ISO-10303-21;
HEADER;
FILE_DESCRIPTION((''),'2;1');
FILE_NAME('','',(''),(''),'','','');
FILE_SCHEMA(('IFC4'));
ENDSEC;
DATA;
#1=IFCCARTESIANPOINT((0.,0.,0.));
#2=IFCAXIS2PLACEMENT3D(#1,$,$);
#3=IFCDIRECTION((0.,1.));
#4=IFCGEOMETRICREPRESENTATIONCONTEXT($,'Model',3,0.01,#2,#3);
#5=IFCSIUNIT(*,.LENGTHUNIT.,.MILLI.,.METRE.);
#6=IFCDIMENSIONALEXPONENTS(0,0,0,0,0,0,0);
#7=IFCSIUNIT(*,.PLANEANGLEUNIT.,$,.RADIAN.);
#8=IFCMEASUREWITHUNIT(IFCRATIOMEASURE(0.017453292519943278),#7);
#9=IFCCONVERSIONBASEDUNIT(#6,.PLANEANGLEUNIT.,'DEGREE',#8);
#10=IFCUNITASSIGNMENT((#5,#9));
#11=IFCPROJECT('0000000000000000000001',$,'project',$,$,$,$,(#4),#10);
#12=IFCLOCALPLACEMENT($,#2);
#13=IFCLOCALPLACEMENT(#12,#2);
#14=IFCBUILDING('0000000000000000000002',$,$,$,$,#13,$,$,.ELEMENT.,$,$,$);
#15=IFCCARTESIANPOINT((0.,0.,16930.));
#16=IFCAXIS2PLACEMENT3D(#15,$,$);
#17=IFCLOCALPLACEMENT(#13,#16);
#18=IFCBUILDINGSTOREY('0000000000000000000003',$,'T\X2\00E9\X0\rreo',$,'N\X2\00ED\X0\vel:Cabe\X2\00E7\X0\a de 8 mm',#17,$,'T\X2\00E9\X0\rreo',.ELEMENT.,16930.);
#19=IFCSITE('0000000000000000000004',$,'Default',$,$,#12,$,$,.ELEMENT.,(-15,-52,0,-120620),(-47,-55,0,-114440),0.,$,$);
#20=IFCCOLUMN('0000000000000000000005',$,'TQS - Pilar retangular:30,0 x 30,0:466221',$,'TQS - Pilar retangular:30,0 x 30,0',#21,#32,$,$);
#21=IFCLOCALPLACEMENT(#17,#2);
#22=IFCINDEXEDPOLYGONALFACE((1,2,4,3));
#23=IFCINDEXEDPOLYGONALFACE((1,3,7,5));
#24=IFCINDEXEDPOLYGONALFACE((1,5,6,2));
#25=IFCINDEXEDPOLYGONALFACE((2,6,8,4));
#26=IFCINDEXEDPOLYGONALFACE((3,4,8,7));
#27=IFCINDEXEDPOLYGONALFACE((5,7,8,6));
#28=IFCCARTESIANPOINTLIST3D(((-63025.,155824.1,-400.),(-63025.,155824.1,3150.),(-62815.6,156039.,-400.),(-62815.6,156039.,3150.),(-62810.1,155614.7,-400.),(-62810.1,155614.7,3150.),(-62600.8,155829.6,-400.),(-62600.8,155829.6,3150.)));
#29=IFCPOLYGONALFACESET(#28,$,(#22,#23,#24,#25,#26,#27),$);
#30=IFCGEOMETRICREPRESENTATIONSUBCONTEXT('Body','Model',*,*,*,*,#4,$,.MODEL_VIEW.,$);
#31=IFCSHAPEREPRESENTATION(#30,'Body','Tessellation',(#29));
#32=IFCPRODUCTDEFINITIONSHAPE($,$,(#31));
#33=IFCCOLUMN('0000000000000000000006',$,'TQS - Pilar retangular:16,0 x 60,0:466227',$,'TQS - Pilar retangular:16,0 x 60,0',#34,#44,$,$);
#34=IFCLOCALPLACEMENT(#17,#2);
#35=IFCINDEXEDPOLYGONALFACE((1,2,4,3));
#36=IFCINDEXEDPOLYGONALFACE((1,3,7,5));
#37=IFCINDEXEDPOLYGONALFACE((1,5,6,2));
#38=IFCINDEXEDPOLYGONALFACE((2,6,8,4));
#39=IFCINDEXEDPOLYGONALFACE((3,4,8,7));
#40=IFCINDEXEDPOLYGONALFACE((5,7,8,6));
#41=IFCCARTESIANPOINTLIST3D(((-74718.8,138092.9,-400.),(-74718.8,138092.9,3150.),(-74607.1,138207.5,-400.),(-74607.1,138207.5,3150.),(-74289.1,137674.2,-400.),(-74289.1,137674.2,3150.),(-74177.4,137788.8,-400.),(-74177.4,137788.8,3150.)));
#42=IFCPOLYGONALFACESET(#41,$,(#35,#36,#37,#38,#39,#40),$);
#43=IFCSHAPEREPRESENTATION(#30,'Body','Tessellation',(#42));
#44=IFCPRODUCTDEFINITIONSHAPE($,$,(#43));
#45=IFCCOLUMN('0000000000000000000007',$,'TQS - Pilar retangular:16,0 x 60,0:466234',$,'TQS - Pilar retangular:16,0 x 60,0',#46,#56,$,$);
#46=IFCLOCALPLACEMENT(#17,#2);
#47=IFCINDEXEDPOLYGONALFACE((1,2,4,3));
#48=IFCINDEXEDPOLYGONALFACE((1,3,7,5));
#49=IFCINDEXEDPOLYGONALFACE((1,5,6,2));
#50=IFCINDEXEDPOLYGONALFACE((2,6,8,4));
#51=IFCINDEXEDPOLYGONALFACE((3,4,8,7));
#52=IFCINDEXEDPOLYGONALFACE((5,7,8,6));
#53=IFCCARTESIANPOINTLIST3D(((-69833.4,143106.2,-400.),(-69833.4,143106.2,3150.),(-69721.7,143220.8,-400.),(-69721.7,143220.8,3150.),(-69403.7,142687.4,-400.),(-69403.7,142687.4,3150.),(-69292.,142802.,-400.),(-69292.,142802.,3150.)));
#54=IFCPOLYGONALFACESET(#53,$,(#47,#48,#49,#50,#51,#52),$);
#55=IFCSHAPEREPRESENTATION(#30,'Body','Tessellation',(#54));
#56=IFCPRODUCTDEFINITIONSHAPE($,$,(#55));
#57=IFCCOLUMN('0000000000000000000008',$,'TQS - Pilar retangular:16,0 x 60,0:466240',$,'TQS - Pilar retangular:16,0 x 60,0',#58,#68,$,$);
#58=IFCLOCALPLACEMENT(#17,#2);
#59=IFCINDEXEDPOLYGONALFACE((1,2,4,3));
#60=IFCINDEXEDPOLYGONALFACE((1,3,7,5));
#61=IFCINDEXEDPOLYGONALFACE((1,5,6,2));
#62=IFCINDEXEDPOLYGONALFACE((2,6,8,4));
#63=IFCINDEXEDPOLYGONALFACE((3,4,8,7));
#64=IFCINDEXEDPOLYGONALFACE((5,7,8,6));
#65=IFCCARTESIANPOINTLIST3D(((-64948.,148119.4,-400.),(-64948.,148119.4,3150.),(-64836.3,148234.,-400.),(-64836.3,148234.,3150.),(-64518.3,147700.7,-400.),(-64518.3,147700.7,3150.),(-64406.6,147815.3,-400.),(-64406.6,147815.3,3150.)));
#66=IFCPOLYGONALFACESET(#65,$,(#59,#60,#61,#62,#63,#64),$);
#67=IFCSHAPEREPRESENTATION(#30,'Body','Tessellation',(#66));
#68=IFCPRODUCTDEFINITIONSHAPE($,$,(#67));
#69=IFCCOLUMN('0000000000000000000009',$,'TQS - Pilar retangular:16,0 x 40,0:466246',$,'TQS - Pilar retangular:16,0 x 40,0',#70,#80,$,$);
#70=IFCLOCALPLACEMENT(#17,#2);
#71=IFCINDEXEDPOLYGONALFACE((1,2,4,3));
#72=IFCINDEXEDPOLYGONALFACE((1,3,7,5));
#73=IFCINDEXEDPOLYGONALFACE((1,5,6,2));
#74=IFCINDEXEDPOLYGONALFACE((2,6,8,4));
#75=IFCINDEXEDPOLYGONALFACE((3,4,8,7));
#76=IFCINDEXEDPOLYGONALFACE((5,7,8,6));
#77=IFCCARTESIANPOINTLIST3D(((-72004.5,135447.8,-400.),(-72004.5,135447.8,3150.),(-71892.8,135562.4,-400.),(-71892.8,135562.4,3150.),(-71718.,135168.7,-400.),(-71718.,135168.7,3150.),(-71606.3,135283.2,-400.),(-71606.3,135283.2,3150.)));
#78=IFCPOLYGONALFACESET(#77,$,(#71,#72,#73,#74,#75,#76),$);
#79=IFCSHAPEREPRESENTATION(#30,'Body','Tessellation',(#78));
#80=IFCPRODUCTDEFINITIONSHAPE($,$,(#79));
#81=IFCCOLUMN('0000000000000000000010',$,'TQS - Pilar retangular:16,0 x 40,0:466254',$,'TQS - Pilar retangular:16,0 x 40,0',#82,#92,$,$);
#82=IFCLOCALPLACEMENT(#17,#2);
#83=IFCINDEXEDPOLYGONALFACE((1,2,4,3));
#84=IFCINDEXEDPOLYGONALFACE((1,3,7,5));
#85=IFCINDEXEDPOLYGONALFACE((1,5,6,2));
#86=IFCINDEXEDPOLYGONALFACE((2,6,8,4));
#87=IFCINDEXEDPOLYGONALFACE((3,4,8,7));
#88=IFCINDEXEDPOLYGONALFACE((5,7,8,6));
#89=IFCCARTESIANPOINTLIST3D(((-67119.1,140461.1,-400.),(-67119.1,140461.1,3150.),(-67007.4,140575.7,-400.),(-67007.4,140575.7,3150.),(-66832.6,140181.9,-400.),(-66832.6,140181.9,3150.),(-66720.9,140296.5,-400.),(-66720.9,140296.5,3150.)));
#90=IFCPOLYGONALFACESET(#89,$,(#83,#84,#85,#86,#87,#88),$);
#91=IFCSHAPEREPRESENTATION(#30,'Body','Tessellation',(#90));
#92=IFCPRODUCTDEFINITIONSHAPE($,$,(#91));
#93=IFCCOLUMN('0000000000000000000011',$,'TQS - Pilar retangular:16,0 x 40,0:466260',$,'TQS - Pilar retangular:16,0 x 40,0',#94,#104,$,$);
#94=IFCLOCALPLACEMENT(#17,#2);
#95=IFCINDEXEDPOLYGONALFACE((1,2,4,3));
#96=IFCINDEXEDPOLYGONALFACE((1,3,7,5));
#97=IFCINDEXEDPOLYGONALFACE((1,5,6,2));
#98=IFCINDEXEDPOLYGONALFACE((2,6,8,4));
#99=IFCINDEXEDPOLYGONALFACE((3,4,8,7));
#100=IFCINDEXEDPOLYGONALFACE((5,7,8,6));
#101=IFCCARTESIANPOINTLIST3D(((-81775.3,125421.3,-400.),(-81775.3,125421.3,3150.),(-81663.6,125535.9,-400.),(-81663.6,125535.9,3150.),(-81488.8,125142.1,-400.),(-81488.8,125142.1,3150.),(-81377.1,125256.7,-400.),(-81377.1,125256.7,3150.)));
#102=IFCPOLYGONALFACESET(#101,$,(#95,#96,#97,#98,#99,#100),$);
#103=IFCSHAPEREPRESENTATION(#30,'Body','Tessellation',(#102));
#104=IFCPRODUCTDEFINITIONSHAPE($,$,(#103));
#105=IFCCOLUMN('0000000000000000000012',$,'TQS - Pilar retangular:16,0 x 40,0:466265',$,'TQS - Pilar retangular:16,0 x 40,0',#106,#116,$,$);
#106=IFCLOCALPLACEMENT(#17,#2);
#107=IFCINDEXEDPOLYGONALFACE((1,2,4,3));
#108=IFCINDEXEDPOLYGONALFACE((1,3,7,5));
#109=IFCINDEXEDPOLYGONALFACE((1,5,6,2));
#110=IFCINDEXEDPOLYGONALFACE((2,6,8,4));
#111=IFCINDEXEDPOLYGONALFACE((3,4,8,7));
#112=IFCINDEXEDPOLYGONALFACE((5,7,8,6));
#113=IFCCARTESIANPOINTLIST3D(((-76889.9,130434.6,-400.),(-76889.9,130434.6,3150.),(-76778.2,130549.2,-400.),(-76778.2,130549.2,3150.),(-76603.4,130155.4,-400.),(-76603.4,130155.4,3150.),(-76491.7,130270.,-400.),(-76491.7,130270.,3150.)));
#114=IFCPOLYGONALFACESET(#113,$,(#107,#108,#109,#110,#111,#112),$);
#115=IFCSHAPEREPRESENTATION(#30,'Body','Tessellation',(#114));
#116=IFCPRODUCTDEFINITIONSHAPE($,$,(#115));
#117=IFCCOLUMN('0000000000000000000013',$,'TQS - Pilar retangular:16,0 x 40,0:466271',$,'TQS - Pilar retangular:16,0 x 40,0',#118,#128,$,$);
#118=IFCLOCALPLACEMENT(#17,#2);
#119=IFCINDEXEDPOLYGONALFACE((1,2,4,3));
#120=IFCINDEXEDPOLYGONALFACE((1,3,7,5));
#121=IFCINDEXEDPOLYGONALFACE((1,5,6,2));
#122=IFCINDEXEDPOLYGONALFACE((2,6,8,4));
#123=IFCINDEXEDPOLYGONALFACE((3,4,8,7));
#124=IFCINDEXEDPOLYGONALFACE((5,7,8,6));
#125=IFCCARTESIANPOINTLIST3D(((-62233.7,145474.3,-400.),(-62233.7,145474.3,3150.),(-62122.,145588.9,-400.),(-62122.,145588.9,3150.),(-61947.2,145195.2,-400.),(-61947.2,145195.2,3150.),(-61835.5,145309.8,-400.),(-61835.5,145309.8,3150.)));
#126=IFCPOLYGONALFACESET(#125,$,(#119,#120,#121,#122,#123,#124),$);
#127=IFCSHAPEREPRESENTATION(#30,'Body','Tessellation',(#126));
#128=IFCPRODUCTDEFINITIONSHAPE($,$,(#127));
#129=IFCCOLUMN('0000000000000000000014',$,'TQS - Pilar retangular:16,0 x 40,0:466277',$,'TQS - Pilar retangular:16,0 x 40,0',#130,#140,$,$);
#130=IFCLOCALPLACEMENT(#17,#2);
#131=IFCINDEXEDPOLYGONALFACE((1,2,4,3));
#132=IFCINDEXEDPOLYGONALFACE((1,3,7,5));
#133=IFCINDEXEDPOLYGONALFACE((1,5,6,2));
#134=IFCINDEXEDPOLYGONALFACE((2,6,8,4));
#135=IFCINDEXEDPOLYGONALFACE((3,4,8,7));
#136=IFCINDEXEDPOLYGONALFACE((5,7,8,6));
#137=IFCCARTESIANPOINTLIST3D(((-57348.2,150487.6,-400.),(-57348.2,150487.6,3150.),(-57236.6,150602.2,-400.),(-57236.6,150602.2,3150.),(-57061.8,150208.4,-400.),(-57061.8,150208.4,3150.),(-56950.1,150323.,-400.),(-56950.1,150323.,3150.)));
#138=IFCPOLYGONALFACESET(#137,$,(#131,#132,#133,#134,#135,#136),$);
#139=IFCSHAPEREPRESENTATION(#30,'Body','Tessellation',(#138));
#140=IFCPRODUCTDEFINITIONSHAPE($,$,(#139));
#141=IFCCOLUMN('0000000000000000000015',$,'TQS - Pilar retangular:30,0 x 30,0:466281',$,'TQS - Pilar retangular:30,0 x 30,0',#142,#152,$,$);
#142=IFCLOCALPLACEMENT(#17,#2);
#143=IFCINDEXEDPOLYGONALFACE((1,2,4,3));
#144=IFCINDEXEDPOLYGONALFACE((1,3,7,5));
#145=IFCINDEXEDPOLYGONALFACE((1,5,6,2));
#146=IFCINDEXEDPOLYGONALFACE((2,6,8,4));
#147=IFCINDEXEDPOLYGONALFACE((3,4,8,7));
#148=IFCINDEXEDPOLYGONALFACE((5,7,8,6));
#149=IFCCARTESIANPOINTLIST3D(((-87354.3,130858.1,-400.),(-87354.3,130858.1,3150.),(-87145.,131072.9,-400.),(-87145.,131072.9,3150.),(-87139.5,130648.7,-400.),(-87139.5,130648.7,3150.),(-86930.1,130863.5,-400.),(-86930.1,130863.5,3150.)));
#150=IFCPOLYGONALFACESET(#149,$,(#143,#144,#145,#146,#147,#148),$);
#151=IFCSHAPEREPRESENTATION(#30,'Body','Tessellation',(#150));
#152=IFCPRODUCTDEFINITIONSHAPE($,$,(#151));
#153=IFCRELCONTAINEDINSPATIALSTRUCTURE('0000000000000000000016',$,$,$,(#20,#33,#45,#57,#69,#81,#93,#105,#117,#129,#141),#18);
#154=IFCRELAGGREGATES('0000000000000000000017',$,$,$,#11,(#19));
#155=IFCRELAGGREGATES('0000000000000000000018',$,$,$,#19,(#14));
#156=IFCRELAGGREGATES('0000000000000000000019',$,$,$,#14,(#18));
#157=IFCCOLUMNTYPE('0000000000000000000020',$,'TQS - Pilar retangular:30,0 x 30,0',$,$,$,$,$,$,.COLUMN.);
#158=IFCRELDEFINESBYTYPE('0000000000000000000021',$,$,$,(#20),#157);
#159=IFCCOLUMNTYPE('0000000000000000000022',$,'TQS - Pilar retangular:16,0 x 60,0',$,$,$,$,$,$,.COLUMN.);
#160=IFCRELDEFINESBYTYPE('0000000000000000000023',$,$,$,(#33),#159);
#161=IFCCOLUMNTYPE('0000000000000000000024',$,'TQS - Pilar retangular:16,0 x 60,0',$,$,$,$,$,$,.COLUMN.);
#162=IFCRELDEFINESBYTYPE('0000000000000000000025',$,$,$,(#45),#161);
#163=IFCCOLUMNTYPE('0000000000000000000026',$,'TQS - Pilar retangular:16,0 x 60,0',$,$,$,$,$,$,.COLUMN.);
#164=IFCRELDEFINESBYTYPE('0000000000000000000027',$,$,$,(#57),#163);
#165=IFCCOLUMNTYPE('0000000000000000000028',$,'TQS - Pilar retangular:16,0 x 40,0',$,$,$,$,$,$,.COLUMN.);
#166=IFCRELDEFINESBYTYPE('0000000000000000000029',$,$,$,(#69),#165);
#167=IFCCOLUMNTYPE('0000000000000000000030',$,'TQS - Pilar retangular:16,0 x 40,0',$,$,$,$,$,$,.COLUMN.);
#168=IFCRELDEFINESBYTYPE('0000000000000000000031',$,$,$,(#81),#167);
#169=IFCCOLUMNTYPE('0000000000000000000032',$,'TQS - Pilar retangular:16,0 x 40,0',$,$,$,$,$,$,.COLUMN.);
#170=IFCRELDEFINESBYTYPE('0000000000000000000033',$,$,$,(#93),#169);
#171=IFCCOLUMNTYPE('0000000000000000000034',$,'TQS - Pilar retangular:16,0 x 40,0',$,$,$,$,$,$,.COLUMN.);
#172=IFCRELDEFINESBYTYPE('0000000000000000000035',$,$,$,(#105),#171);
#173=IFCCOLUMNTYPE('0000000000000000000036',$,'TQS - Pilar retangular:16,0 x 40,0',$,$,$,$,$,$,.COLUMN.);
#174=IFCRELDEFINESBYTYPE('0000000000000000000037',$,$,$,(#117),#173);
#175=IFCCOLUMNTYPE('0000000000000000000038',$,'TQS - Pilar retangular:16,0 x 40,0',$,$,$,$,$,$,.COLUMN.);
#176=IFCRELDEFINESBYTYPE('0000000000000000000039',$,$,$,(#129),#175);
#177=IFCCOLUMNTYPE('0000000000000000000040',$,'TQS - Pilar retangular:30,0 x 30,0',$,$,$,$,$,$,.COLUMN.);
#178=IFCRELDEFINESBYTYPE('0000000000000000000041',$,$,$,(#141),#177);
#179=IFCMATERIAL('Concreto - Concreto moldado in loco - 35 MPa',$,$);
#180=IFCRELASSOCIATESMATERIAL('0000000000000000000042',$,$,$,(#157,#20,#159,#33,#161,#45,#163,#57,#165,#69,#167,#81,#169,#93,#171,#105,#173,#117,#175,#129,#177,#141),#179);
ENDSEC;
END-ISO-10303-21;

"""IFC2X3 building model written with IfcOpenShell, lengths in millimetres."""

from ifc_helpers import new_model, entity, si_unit, converted_unit, direction, frame, frame_2d, origin, origin_2d_with_axis, place, context, subcontext, project, spatial, rectangle, extrude, source, transform, mapped, material, type_object, type_shapes, element, save


model = new_model("IFC2X3")

# Units and contexts
model_context = context("Model", 3, precision=0.01, world=origin(), true_north=direction((0.0, 1.0)))
body_context = subcontext(model_context, "Body", "Model", "MODEL_VIEW")
ifc_project = project(units=[si_unit("LENGTHUNIT", "METRE", prefix="MILLI"), converted_unit("PLANEANGLEUNIT", "DEGREE", entity("IfcRatioMeasure", 0.017453292519943278), si_unit("PLANEANGLEUNIT", "RADIAN"), dimensions=[0, 0, 0, 0, 0, 0, 0])], contexts=[model_context])

# Site, building, storey
site_placement = place(None, origin())
site = spatial("IfcSite", under=ifc_project, at=site_placement, Name="Default", CompositionType="ELEMENT", RefLatitude=(-15, -52, 0, -120620), RefLongitude=(-47, -55, 0, -114440), RefElevation=0.0)
building_placement = place(site_placement, origin())
building = spatial("IfcBuilding", under=site, at=building_placement, CompositionType="ELEMENT")
storey_placement = place(building_placement, frame((0.0, 0.0, 16930.0)))
storey = spatial("IfcBuildingStorey", under=building, at=storey_placement, Name="Térreo", ObjectType="Nível:Cabeça de 8 mm", LongName="Térreo", CompositionType="ELEMENT", Elevation=16930.0)

# Columns
ifc_material = material(Name="Concreto - Concreto moldado in loco - 35 MPa")
column_type_1 = type_object("IfcColumnType", Name="TQS - Pilar retangular:30,0 x 30,0", PredefinedType="COLUMN", material=ifc_material)
shared_shape_1 = source(origin(), body_context, "Body", "SweptSolid", [
    extrude(rectangle(XDim=300.0, YDim=300.0, at=origin_2d_with_axis()), frame((-62812.9, 155826.8, 16530.0), z_axis=(0.0, 0.0, 1.0), x_axis=(-0.71618, 0.697915, 0.0)), (0.0, 0.0, 1.0), 3550.0),
])
type_shapes(column_type_1, [shared_shape_1])
column_1_placement = place(storey_placement, frame((0.0, 0.0, -16930.0)))
element("IfcColumn", 1, at=column_1_placement, inside=storey, type_object=column_type_1, material=ifc_material, Name="TQS - Pilar retangular:30,0 x 30,0:466221", ObjectType="TQS - Pilar retangular:30,0 x 30,0", context=body_context, shape_type="MappedRepresentation", body=[
    mapped(shared_shape_1, transform((0.0, 0.0, 0.0), scale=1.0)),
])
column_type_2 = type_object("IfcColumnType", Name="TQS - Pilar retangular:16,0 x 60,0", PredefinedType="COLUMN", material=ifc_material)
shared_shape_2 = source(origin(), body_context, "Body", "SweptSolid", [
    extrude(rectangle(XDim=600.0, YDim=160.0, at=frame_2d((0.0, 0.0), x_axis=(1.0, 0.0))), frame((-74448.1, 137940.8, 16530.0), z_axis=(0.0, 0.0, 1.0), x_axis=(-0.71618, 0.697915, 0.0)), (0.0, 0.0, 1.0), 3550.0),
])
type_shapes(column_type_2, [shared_shape_2])
column_2_placement = place(storey_placement, frame((0.0, 0.0, -16930.0)))
element("IfcColumn", 2, at=column_2_placement, inside=storey, type_object=column_type_2, material=ifc_material, Name="TQS - Pilar retangular:16,0 x 60,0:466227", ObjectType="TQS - Pilar retangular:16,0 x 60,0", context=body_context, shape_type="MappedRepresentation", body=[
    mapped(shared_shape_2, transform((0.0, 0.0, 0.0), scale=1.0)),
])
column_type_3 = type_object("IfcColumnType", Name="TQS - Pilar retangular:16,0 x 60,0", PredefinedType="COLUMN", material=ifc_material)
shared_shape_3 = source(origin(), body_context, "Body", "SweptSolid", [
    extrude(rectangle(XDim=600.0, YDim=160.0, at=frame_2d((0.0, 0.0), x_axis=(1.0, 0.0))), frame((-69562.7, 142954.1, 16530.0), z_axis=(0.0, 0.0, 1.0), x_axis=(-0.71618, 0.697915, 0.0)), (0.0, 0.0, 1.0), 3550.0),
])
type_shapes(column_type_3, [shared_shape_3])
column_3_placement = place(storey_placement, frame((0.0, 0.0, -16930.0)))
element("IfcColumn", 3, at=column_3_placement, inside=storey, type_object=column_type_3, material=ifc_material, Name="TQS - Pilar retangular:16,0 x 60,0:466234", ObjectType="TQS - Pilar retangular:16,0 x 60,0", context=body_context, shape_type="MappedRepresentation", body=[
    mapped(shared_shape_3, transform((0.0, 0.0, 0.0), scale=1.0)),
])
column_type_4 = type_object("IfcColumnType", Name="TQS - Pilar retangular:16,0 x 60,0", PredefinedType="COLUMN", material=ifc_material)
shared_shape_4 = source(origin(), body_context, "Body", "SweptSolid", [
    extrude(rectangle(XDim=600.0, YDim=160.0, at=frame_2d((0.0, 0.0), x_axis=(1.0, 0.0))), frame((-64677.3, 147967.4, 16530.0), z_axis=(0.0, 0.0, 1.0), x_axis=(-0.71618, 0.697915, 0.0)), (0.0, 0.0, 1.0), 3550.0),
])
type_shapes(column_type_4, [shared_shape_4])
column_4_placement = place(storey_placement, frame((0.0, 0.0, -16930.0)))
element("IfcColumn", 4, at=column_4_placement, inside=storey, type_object=column_type_4, material=ifc_material, Name="TQS - Pilar retangular:16,0 x 60,0:466240", ObjectType="TQS - Pilar retangular:16,0 x 60,0", context=body_context, shape_type="MappedRepresentation", body=[
    mapped(shared_shape_4, transform((0.0, 0.0, 0.0), scale=1.0)),
])
column_type_5 = type_object("IfcColumnType", Name="TQS - Pilar retangular:16,0 x 40,0", PredefinedType="COLUMN", material=ifc_material)
shared_shape_5 = source(origin(), body_context, "Body", "SweptSolid", [
    extrude(rectangle(XDim=400.0, YDim=160.0, at=frame_2d((0.0, 0.0), x_axis=(1.0, 0.0))), frame((-71805.4, 135365.5, 16530.0), z_axis=(0.0, 0.0, 1.0), x_axis=(-0.71618, 0.697915, 0.0)), (0.0, 0.0, 1.0), 3550.0),
])
type_shapes(column_type_5, [shared_shape_5])
column_5_placement = place(storey_placement, frame((0.0, 0.0, -16930.0)))
element("IfcColumn", 5, at=column_5_placement, inside=storey, type_object=column_type_5, material=ifc_material, Name="TQS - Pilar retangular:16,0 x 40,0:466246", ObjectType="TQS - Pilar retangular:16,0 x 40,0", context=body_context, shape_type="MappedRepresentation", body=[
    mapped(shared_shape_5, transform((0.0, 0.0, 0.0), scale=1.0)),
])
column_type_6 = type_object("IfcColumnType", Name="TQS - Pilar retangular:16,0 x 40,0", PredefinedType="COLUMN", material=ifc_material)
shared_shape_6 = source(origin(), body_context, "Body", "SweptSolid", [
    extrude(rectangle(XDim=400.0, YDim=160.0, at=frame_2d((0.0, 0.0), x_axis=(1.0, 0.0))), frame((-66920.0, 140378.8, 16530.0), z_axis=(0.0, 0.0, 1.0), x_axis=(-0.71618, 0.697915, 0.0)), (0.0, 0.0, 1.0), 3550.0),
])
type_shapes(column_type_6, [shared_shape_6])
column_6_placement = place(storey_placement, frame((0.0, 0.0, -16930.0)))
element("IfcColumn", 6, at=column_6_placement, inside=storey, type_object=column_type_6, material=ifc_material, Name="TQS - Pilar retangular:16,0 x 40,0:466254", ObjectType="TQS - Pilar retangular:16,0 x 40,0", context=body_context, shape_type="MappedRepresentation", body=[
    mapped(shared_shape_6, transform((0.0, 0.0, 0.0), scale=1.0)),
])
column_type_7 = type_object("IfcColumnType", Name="TQS - Pilar retangular:16,0 x 40,0", PredefinedType="COLUMN", material=ifc_material)
shared_shape_7 = source(origin(), body_context, "Body", "SweptSolid", [
    extrude(rectangle(XDim=400.0, YDim=160.0, at=frame_2d((0.0, 0.0), x_axis=(1.0, 0.0))), frame((-81576.2, 125339.0, 16530.0), z_axis=(0.0, 0.0, 1.0), x_axis=(-0.71618, 0.697915, 0.0)), (0.0, 0.0, 1.0), 3550.0),
])
type_shapes(column_type_7, [shared_shape_7])
column_7_placement = place(storey_placement, frame((0.0, 0.0, -16930.0)))
element("IfcColumn", 7, at=column_7_placement, inside=storey, type_object=column_type_7, material=ifc_material, Name="TQS - Pilar retangular:16,0 x 40,0:466260", ObjectType="TQS - Pilar retangular:16,0 x 40,0", context=body_context, shape_type="MappedRepresentation", body=[
    mapped(shared_shape_7, transform((0.0, 0.0, 0.0), scale=1.0)),
])
column_type_8 = type_object("IfcColumnType", Name="TQS - Pilar retangular:16,0 x 40,0", PredefinedType="COLUMN", material=ifc_material)
shared_shape_8 = source(origin(), body_context, "Body", "SweptSolid", [
    extrude(rectangle(XDim=400.0, YDim=160.0, at=frame_2d((0.0, 0.0), x_axis=(1.0, 0.0))), frame((-76690.8, 130352.3, 16530.0), z_axis=(0.0, 0.0, 1.0), x_axis=(-0.71618, 0.697915, 0.0)), (0.0, 0.0, 1.0), 3550.0),
])
type_shapes(column_type_8, [shared_shape_8])
column_8_placement = place(storey_placement, frame((0.0, 0.0, -16930.0)))
element("IfcColumn", 8, at=column_8_placement, inside=storey, type_object=column_type_8, material=ifc_material, Name="TQS - Pilar retangular:16,0 x 40,0:466265", ObjectType="TQS - Pilar retangular:16,0 x 40,0", context=body_context, shape_type="MappedRepresentation", body=[
    mapped(shared_shape_8, transform((0.0, 0.0, 0.0), scale=1.0)),
])
column_type_9 = type_object("IfcColumnType", Name="TQS - Pilar retangular:16,0 x 40,0", PredefinedType="COLUMN", material=ifc_material)
shared_shape_9 = source(origin(), body_context, "Body", "SweptSolid", [
    extrude(rectangle(XDim=400.0, YDim=160.0, at=frame_2d((0.0, 0.0), x_axis=(1.0, 0.0))), frame((-62034.6, 145392.1, 16530.0), z_axis=(0.0, 0.0, 1.0), x_axis=(-0.71618, 0.697915, 0.0)), (0.0, 0.0, 1.0), 3550.0),
])
type_shapes(column_type_9, [shared_shape_9])
column_9_placement = place(storey_placement, frame((0.0, 0.0, -16930.0)))
element("IfcColumn", 9, at=column_9_placement, inside=storey, type_object=column_type_9, material=ifc_material, Name="TQS - Pilar retangular:16,0 x 40,0:466271", ObjectType="TQS - Pilar retangular:16,0 x 40,0", context=body_context, shape_type="MappedRepresentation", body=[
    mapped(shared_shape_9, transform((0.0, 0.0, 0.0), scale=1.0)),
])
column_type_10 = type_object("IfcColumnType", Name="TQS - Pilar retangular:16,0 x 40,0", PredefinedType="COLUMN", material=ifc_material)
shared_shape_10 = source(origin(), body_context, "Body", "SweptSolid", [
    extrude(rectangle(XDim=400.0, YDim=160.0, at=frame_2d((0.0, 0.0), x_axis=(1.0, 0.0))), frame((-57149.2, 150405.3, 16530.0), z_axis=(0.0, 0.0, 1.0), x_axis=(-0.71618, 0.697915, 0.0)), (0.0, 0.0, 1.0), 3550.0),
])
type_shapes(column_type_10, [shared_shape_10])
column_10_placement = place(storey_placement, frame((0.0, 0.0, -16930.0)))
element("IfcColumn", 10, at=column_10_placement, inside=storey, type_object=column_type_10, material=ifc_material, Name="TQS - Pilar retangular:16,0 x 40,0:466277", ObjectType="TQS - Pilar retangular:16,0 x 40,0", context=body_context, shape_type="MappedRepresentation", body=[
    mapped(shared_shape_10, transform((0.0, 0.0, 0.0), scale=1.0)),
])
column_type_11 = type_object("IfcColumnType", Name="TQS - Pilar retangular:30,0 x 30,0", PredefinedType="COLUMN", material=ifc_material)
shared_shape_11 = source(origin(), body_context, "Body", "SweptSolid", [
    extrude(rectangle(XDim=300.0, YDim=300.0, at=origin_2d_with_axis()), frame((-87142.2, 130860.8, 16530.0), z_axis=(0.0, 0.0, 1.0), x_axis=(-0.71618, 0.697915, 0.0)), (0.0, 0.0, 1.0), 3550.0),
])
type_shapes(column_type_11, [shared_shape_11])
column_11_placement = place(storey_placement, frame((0.0, 0.0, -16930.0)))
element("IfcColumn", 11, at=column_11_placement, inside=storey, type_object=column_type_11, material=ifc_material, Name="TQS - Pilar retangular:30,0 x 30,0:466281", ObjectType="TQS - Pilar retangular:30,0 x 30,0", context=body_context, shape_type="MappedRepresentation", body=[
    mapped(shared_shape_11, transform((0.0, 0.0, 0.0), scale=1.0)),
])

save(model, "model.ifc")
